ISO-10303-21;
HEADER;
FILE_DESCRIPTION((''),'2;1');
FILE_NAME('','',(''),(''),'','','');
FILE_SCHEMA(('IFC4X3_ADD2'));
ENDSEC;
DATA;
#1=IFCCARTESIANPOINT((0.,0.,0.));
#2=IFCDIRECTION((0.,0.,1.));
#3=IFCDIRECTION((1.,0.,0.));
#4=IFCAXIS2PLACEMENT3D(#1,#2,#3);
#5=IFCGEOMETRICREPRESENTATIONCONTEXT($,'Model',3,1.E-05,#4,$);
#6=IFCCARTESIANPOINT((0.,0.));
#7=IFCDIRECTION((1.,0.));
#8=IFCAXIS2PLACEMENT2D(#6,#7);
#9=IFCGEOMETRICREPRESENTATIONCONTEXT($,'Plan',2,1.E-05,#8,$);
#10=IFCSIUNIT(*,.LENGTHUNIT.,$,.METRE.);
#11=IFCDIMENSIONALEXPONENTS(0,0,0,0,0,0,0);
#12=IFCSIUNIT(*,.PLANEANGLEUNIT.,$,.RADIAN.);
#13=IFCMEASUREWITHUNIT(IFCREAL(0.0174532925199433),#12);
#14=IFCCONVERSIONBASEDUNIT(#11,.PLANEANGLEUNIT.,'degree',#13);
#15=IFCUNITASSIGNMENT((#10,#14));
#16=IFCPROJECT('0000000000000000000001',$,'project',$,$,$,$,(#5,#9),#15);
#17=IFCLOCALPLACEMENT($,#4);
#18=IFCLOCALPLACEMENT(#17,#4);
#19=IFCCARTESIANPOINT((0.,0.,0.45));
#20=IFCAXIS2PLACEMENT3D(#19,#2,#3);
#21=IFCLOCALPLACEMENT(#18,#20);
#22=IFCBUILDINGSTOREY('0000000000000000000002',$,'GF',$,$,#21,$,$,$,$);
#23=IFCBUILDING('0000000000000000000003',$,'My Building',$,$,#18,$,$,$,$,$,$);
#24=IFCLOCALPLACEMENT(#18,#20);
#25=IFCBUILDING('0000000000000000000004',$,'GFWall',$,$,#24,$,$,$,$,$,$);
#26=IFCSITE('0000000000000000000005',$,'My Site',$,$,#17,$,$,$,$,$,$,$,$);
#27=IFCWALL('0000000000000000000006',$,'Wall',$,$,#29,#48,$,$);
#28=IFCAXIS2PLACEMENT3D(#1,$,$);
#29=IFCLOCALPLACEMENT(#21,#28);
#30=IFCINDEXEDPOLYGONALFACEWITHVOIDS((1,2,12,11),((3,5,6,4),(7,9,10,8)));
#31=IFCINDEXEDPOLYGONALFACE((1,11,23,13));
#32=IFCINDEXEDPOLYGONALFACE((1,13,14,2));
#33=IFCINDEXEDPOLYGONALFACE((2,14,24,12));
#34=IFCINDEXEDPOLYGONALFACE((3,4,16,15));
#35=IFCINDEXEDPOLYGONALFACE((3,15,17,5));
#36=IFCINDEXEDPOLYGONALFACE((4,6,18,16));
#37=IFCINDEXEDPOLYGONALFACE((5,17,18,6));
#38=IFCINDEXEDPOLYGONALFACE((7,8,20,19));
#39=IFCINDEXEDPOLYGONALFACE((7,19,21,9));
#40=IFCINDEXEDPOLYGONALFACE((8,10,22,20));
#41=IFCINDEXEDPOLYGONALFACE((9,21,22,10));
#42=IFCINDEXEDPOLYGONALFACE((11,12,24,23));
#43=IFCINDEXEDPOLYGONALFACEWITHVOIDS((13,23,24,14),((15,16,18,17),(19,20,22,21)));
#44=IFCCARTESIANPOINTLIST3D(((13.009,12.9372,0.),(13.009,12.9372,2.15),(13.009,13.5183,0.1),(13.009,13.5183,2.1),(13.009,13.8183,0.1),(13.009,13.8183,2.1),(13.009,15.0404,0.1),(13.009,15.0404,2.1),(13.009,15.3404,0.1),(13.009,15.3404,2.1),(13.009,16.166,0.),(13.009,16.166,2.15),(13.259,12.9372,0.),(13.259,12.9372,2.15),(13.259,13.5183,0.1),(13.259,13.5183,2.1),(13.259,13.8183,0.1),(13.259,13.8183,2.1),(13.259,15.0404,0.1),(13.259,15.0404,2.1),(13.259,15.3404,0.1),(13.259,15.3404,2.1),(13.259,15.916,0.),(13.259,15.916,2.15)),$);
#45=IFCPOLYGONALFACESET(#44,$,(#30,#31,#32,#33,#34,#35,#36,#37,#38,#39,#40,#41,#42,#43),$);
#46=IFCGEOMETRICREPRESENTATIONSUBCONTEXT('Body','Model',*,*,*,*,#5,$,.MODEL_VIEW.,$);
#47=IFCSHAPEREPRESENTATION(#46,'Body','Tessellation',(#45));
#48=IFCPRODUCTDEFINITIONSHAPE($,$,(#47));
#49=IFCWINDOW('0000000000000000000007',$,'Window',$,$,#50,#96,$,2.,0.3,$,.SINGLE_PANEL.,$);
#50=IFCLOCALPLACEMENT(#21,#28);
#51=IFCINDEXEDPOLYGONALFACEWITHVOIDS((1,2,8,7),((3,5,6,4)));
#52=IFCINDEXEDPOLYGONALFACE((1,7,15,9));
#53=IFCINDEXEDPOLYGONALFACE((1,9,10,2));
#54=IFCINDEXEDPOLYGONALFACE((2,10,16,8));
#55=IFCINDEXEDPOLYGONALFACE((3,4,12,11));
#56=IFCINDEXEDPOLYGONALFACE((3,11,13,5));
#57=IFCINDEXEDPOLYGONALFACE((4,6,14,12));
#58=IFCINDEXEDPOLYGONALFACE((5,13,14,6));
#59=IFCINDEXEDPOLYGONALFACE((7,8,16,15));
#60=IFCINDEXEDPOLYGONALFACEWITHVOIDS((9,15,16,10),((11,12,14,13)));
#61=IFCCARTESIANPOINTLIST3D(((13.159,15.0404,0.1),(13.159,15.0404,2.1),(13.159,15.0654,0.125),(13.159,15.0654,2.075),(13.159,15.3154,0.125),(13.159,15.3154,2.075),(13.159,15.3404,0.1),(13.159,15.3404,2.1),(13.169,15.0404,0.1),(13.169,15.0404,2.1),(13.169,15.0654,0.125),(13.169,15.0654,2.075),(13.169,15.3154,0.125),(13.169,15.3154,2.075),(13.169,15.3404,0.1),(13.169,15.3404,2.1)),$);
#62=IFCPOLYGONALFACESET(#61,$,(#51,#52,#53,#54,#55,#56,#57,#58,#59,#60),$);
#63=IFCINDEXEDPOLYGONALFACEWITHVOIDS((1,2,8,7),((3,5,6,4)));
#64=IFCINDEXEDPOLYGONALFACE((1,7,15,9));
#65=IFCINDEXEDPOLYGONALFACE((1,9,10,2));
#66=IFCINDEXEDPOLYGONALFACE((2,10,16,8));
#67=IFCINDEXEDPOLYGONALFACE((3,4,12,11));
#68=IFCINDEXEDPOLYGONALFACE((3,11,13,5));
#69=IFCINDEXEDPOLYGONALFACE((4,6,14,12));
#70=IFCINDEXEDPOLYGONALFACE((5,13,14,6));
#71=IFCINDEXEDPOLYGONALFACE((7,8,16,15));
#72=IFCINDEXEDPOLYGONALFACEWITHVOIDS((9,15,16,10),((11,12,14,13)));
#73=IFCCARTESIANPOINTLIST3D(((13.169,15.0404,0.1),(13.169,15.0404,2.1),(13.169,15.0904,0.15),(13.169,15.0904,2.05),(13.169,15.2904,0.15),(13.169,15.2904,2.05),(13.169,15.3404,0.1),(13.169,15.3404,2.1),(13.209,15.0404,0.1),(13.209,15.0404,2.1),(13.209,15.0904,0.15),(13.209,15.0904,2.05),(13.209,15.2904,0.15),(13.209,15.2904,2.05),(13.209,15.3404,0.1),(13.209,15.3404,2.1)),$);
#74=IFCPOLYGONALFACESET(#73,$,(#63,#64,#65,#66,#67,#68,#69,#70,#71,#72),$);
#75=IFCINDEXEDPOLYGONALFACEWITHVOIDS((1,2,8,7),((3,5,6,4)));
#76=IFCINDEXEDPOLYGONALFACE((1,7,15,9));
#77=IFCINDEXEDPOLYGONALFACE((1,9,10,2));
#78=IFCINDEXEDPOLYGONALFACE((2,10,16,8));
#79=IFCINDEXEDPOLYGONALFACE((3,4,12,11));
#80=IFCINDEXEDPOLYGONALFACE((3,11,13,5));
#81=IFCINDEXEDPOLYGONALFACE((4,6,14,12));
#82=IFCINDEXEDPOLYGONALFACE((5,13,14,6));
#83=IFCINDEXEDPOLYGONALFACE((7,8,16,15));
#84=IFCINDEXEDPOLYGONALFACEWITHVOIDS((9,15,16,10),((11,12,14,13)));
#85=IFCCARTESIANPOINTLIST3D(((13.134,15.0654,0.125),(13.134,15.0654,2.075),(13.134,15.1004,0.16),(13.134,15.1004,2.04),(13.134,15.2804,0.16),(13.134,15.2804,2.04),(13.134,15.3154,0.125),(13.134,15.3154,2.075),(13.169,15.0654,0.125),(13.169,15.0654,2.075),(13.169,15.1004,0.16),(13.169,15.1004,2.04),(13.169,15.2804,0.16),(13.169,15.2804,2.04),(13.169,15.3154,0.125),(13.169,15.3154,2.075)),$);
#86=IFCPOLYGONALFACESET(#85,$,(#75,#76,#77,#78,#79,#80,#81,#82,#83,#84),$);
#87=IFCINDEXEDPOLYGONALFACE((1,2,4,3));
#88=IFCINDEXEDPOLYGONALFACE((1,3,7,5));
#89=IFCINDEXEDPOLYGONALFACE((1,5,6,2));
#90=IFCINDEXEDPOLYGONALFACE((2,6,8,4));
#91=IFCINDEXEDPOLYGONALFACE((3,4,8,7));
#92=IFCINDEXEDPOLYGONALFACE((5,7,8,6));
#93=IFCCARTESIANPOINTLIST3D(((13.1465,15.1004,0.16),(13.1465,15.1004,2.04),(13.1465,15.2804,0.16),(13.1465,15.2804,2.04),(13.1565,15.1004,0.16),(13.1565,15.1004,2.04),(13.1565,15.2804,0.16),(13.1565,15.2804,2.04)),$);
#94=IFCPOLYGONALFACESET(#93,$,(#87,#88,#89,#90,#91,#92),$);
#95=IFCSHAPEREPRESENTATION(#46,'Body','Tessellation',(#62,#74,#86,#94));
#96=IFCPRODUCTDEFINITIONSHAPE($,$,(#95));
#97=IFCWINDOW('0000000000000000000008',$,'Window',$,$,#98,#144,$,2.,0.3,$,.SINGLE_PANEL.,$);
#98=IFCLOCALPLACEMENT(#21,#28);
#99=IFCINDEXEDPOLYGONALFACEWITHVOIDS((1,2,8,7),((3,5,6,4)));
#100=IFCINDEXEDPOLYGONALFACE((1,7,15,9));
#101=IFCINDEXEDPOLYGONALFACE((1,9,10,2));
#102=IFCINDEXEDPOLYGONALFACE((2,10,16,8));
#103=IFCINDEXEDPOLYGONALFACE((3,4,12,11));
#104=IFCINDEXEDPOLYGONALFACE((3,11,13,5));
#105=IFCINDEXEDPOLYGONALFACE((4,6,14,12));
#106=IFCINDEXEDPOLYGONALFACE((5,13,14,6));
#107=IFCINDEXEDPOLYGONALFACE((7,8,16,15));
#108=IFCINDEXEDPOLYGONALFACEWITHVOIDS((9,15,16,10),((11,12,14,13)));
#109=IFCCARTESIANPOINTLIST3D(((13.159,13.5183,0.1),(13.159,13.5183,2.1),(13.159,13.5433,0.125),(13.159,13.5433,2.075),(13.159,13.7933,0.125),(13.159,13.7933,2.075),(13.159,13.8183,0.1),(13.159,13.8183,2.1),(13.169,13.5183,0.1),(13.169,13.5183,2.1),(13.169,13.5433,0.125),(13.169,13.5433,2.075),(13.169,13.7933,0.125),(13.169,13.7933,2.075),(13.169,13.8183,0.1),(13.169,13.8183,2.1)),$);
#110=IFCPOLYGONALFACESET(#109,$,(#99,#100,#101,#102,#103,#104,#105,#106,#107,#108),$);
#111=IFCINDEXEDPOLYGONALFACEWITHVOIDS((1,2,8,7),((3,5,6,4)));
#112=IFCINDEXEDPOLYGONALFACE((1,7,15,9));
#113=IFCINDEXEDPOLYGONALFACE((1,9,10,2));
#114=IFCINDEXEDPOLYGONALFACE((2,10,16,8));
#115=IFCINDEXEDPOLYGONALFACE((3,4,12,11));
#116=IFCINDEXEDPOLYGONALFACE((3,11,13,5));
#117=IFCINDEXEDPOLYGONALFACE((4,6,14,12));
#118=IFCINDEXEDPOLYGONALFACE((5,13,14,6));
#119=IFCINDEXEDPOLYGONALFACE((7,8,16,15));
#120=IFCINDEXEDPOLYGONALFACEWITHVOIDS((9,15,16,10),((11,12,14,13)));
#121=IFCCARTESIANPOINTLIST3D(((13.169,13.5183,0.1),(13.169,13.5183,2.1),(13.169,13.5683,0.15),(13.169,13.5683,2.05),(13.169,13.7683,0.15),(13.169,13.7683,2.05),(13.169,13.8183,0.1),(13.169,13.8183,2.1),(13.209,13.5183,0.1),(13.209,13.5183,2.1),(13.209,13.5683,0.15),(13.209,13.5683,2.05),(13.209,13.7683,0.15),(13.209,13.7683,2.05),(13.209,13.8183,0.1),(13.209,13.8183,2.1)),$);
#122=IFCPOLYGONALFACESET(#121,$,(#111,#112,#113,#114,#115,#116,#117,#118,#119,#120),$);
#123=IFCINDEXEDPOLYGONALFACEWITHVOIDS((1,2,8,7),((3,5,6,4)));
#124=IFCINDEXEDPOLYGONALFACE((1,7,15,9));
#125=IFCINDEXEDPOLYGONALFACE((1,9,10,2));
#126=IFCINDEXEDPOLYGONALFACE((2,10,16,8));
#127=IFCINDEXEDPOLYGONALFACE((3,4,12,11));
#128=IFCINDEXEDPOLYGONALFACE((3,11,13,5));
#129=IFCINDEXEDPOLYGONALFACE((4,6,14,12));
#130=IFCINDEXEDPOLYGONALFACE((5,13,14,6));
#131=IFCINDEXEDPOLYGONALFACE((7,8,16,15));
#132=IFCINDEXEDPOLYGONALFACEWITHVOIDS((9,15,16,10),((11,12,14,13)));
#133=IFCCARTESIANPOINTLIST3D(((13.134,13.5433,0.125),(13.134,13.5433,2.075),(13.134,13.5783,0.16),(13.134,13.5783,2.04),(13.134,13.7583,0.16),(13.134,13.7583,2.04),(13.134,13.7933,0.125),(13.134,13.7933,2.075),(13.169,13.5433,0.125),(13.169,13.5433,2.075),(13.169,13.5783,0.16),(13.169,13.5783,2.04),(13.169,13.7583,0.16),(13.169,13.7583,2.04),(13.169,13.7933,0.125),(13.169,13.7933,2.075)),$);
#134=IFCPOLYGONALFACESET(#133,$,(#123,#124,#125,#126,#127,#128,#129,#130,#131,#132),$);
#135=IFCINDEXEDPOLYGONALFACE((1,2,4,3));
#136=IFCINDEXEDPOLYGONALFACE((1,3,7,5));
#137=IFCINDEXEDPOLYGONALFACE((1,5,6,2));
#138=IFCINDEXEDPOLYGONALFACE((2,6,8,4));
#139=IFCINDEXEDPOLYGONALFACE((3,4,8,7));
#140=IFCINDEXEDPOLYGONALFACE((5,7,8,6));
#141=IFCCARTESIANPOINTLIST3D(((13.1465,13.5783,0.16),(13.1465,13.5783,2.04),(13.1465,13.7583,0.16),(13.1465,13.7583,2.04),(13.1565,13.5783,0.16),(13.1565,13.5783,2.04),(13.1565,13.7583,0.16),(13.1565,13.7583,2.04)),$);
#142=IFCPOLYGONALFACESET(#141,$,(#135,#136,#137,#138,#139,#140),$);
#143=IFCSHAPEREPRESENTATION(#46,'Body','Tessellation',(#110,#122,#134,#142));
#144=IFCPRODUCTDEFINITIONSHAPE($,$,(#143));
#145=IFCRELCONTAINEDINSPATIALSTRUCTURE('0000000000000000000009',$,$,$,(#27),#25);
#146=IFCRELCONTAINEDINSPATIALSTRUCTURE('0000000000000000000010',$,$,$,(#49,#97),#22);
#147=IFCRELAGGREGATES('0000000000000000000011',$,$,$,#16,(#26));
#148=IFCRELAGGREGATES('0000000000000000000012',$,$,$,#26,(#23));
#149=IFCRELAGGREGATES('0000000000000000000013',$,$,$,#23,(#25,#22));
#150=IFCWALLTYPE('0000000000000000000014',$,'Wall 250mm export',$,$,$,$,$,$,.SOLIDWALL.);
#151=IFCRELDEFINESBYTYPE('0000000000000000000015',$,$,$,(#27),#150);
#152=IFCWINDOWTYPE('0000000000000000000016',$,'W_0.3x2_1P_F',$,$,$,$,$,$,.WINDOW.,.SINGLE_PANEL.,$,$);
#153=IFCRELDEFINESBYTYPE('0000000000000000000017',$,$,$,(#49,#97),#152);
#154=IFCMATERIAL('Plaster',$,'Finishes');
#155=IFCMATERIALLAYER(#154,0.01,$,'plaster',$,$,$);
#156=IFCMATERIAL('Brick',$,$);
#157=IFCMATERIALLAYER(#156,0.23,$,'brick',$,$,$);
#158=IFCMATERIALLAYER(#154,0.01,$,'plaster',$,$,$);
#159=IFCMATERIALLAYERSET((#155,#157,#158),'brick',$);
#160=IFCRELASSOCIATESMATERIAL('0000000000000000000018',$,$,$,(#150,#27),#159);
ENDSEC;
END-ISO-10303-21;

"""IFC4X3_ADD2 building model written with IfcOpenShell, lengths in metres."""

from ifc_helpers import new_model, entity, si_unit, converted_unit, frame, origin_with_axes, origin_2d_with_axis, place, context, subcontext, project, spatial, line, indexed_curve, outline, extrude, shape, source, transform, mapped, material, layer, layer_set, layer_usage, type_object, type_shapes, element, fill, save


model = new_model("IFC4X3_ADD2")

# Units and contexts
model_context = context("Model", 3, precision=1e-05, world=origin_with_axes())
plan_context = context("Plan", 2, precision=1e-05, world=origin_2d_with_axis())
body_context_1 = subcontext(model_context, "Body", "Model", "MODEL_VIEW")
body_context_2 = subcontext(plan_context, "Body", "Plan", "PLAN_VIEW")
ifc_project = project(units=[si_unit("LENGTHUNIT", "METRE"), converted_unit("PLANEANGLEUNIT", "degree", entity("IfcReal", 0.0174532925199433), si_unit("PLANEANGLEUNIT", "RADIAN"), dimensions=[0, 0, 0, 0, 0, 0, 0])], contexts=[model_context, plan_context])

# Site, buildings
site_placement = place(None, origin_with_axes())
site = spatial("IfcSite", under=ifc_project, at=site_placement, Name="My Site")
building_1_placement = place(site_placement, origin_with_axes())
building_1 = spatial("IfcBuilding", under=site, at=building_1_placement, Name="My Building")
building_2_placement = place(building_1_placement, frame((0.0, 0.0, 0.45), z_axis=(0.0, 0.0, 1.0), x_axis=(1.0, 0.0, 0.0)))
building_2 = spatial("IfcBuilding", under=building_1, at=building_2_placement, Name="GFWall")

# Shared definitions
ifc_material_1 = material(Name="Plaster", Category="Finishes")
ifc_layer_1 = layer(ifc_material_1, 0.01, Name="plaster")
ifc_material_2 = material(Name="Brick")
ifc_layer_2 = layer(ifc_material_2, 0.23, Name="brick")
ifc_layer_3 = layer(ifc_material_1, 0.01, Name="plaster")
ifc_layer_set = layer_set([ifc_layer_1, ifc_layer_2, ifc_layer_3], Name="brick")
wall_type = type_object("IfcWallType", Name="Wall 250mm export", PredefinedType="SOLIDWALL", material=ifc_layer_set)

# Shared definitions
storey_placement = place(building_1_placement, frame((0.0, 0.0, 0.45), z_axis=(0.0, 0.0, 1.0), x_axis=(1.0, 0.0, 0.0)))
storey = spatial("IfcBuildingStorey", under=building_1, at=storey_placement, Name="GF")

# Wall, openings, windows
ifc_layer_usage_1 = layer_usage(ifc_layer_set, "AXIS2", "POSITIVE", 0.0)
wall_1_placement = place(building_2_placement, frame((13.259, 12.9372, 0.0), z_axis=(0.0, 0.0, 1.0), x_axis=(0.0, 1.0, 0.0)))
wall_1 = element("IfcWall", 1, at=wall_1_placement, inside=building_2, type_object=wall_type, material=ifc_layer_usage_1, Name="Wall", context=body_context_1, shape_type="SweptSolid", body=[
    extrude(outline(indexed_curve([(0.0, 0.0), (0.0, 0.25), (3.2288, 0.25), (2.9788, 0.0)], segments=[line(1, 2, 3, 4, 1)])), origin_with_axes(), (0.0, 0.0, 1.0), 2.15),
])
shared_shape_1 = source(origin_with_axes(), body_context_1, "Body", "SweptSolid", [
    extrude(outline(indexed_curve([(0.0, 0.0), (0.3, 0.0), (0.3, 2.0), (0.0, 2.0)], segments=[line(1, 2, 3, 4, 1)])), frame((0.0, -0.6, 0.0), z_axis=(0.0, -1.0, 0.0), x_axis=(1.0, 0.0, 0.0)), (0.0, 0.0, -1.0), 1.2),
])
opening_1_placement = place(wall_1_placement, frame((2.1032, 0.0, 0.1), z_axis=(0.0, 0.0, 1.0), x_axis=(1.0, 0.0, 0.0)))
opening_1 = element("IfcOpeningElement", 2, at=opening_1_placement, cuts=wall_1, PredefinedType="OPENING", context=body_context_1, shape_type="MappedRepresentation", body=[
    mapped(shared_shape_1, transform((0.0, 0.0, 0.0), x_axis=(1.0, 0.0, 0.0), y_axis=(0.0, 1.0, 0.0), z_axis=(0.0, 0.0, 1.0), scale=1.0)),
])
opening_2_placement = place(wall_1_placement, frame((0.5811, 0.0, 0.1), z_axis=(0.0, 0.0, 1.0), x_axis=(1.0, 0.0, 0.0)))
opening_2 = element("IfcOpeningElement", 3, at=opening_2_placement, cuts=wall_1, PredefinedType="OPENING", context=body_context_1, shape_type="MappedRepresentation", body=[
    mapped(shared_shape_1, transform((0.0, 0.0, 0.0), x_axis=(1.0, 0.0, 0.0), y_axis=(0.0, 1.0, 0.0), z_axis=(0.0, 0.0, 1.0), scale=1.0)),
])
window_type_1 = type_object("IfcWindowType", Name="W_0.3x2_1P_F", PartitioningType="SINGLE_PANEL", PredefinedType="WINDOW")
shared_shape_2 = source(origin_with_axes(), body_context_1, "Body", "SweptSolid", [
    extrude(outline(indexed_curve([(0.0, 0.0), (0.3, 0.0), (0.3, 2.0), (0.0, 2.0)], segments=[line(1, 2, 3, 4, 1)]), holes=[indexed_curve([(0.025, 0.025), (0.275, 0.025), (0.275, 1.975), (0.025, 1.975)], segments=[line(1, 2, 3, 4, 1)])]), frame((0.0, 0.09, 0.0), z_axis=(0.0, -1.0, 0.0), x_axis=(1.0, 0.0, 0.0)), (0.0, 0.0, -1.0), 0.01),
    extrude(outline(indexed_curve([(0.0, 0.0), (0.3, 0.0), (0.3, 2.0), (0.0, 2.0)], segments=[line(1, 2, 3, 4, 1)]), holes=[indexed_curve([(0.05, 0.05), (0.25, 0.05), (0.25, 1.95), (0.05, 1.95)], segments=[line(1, 2, 3, 4, 1)])]), frame((0.0, 0.05, 0.0), z_axis=(0.0, -1.0, 0.0), x_axis=(1.0, 0.0, 0.0)), (0.0, 0.0, -1.0), 0.04),
    extrude(outline(indexed_curve([(0.0, 0.0), (0.25, 0.0), (0.25, 1.95), (0.0, 1.95)], segments=[line(1, 2, 3, 4, 1)]), holes=[indexed_curve([(0.035, 0.035), (0.215, 0.035), (0.215, 1.915), (0.035, 1.915)], segments=[line(1, 2, 3, 4, 1)])]), frame((0.025, 0.09, 0.025), z_axis=(0.0, -1.0, 0.0), x_axis=(1.0, 0.0, 0.0)), (0.0, 0.0, -1.0), 0.035),
    extrude(outline(indexed_curve([(0.035, 0.035), (0.215, 0.035), (0.215, 1.915), (0.035, 1.915)], segments=[line(1, 2, 3, 4, 1)])), frame((0.025, 0.1025, 0.025), z_axis=(0.0, -1.0, 0.0), x_axis=(1.0, 0.0, 0.0)), (0.0, 0.0, -1.0), 0.01),
])
shared_shape_3 = source(origin_with_axes(), body_context_2, "Body", "Curve2D", [
    entity("IfcIndexedPolyCurve", entity("IfcCartesianPointList2D", [[0.05, 0.05], [0.25, 0.05]])),
    entity("IfcIndexedPolyCurve", entity("IfcCartesianPointList2D", [[0.0, 0.1], [0.025, 0.1], [0.025, 0.09], [0.05, 0.09], [0.05, 0.05], [0.0, 0.05]]), [entity("IfcLineIndex", [1, 2, 3, 4, 5, 6, 1])]),
    entity("IfcIndexedPolyCurve", entity("IfcCartesianPointList2D", [[0.3, 0.1], [0.275, 0.1], [0.275, 0.09], [0.25, 0.09], [0.25, 0.05], [0.3, 0.05]]), [entity("IfcLineIndex", [1, 2, 3, 4, 5, 6, 1])]),
    entity("IfcIndexedPolyCurve", entity("IfcCartesianPointList2D", [[0.025, 0.09], [0.06, 0.09], [0.06, 0.125], [0.025, 0.125]]), [entity("IfcLineIndex", [1, 2, 3, 4, 1])]),
    entity("IfcIndexedPolyCurve", entity("IfcCartesianPointList2D", [[0.275, 0.09], [0.24, 0.09], [0.24, 0.125], [0.275, 0.125]]), [entity("IfcLineIndex", [1, 2, 3, 4, 1])]),
    entity("IfcIndexedPolyCurve", entity("IfcCartesianPointList2D", [[0.06, 0.09], [0.24, 0.09]])),
    entity("IfcIndexedPolyCurve", entity("IfcCartesianPointList2D", [[0.06, 0.125], [0.24, 0.125]])),
    entity("IfcIndexedPolyCurve", entity("IfcCartesianPointList2D", [[0.06, 0.1075], [0.24, 0.1075]])),
])
type_shapes(window_type_1, [shared_shape_2, shared_shape_3])
window_1_placement = place(opening_1_placement, frame((0.0, 0.0, 0.0), z_axis=(0.0, 0.0, 1.0), x_axis=(1.0, 0.0, 0.0)))
window_1 = element("IfcWindow", 4, at=window_1_placement, inside=storey, type_object=window_type_1, Name="Window", OverallHeight=2.0, OverallWidth=0.3, PartitioningType="SINGLE_PANEL", shapes=[
    shape(body_context_1, "Body", "MappedRepresentation", [mapped(shared_shape_2, transform((0.0, 0.0, 0.0), x_axis=(1.0, 0.0, 0.0), y_axis=(0.0, 1.0, 0.0), z_axis=(0.0, 0.0, 1.0), scale=1.0))]),
    shape(body_context_2, "Body", "MappedRepresentation", [mapped(shared_shape_3, transform((0.0, 0.0, 0.0), x_axis=(1.0, 0.0, 0.0), y_axis=(0.0, 1.0, 0.0), z_axis=(0.0, 0.0, 1.0), scale=1.0))]),
])
fill(opening_1, window_1)
window_2_placement = place(opening_2_placement, frame((0.0, 0.0, 0.0), z_axis=(0.0, 0.0, 1.0), x_axis=(1.0, 0.0, 0.0)))
window_2 = element("IfcWindow", 5, at=window_2_placement, inside=storey, type_object=window_type_1, Name="Window", OverallHeight=2.0, OverallWidth=0.3, PartitioningType="SINGLE_PANEL", shapes=[
    shape(body_context_1, "Body", "MappedRepresentation", [mapped(shared_shape_2, transform((0.0, 0.0, 0.0), x_axis=(1.0, 0.0, 0.0), y_axis=(0.0, 1.0, 0.0), z_axis=(0.0, 0.0, 1.0), scale=1.0))]),
    shape(body_context_2, "Body", "MappedRepresentation", [mapped(shared_shape_3, transform((0.0, 0.0, 0.0), x_axis=(1.0, 0.0, 0.0), y_axis=(0.0, 1.0, 0.0), z_axis=(0.0, 0.0, 1.0), scale=1.0))]),
])
fill(opening_2, window_2)

save(model, "model.ifc")
